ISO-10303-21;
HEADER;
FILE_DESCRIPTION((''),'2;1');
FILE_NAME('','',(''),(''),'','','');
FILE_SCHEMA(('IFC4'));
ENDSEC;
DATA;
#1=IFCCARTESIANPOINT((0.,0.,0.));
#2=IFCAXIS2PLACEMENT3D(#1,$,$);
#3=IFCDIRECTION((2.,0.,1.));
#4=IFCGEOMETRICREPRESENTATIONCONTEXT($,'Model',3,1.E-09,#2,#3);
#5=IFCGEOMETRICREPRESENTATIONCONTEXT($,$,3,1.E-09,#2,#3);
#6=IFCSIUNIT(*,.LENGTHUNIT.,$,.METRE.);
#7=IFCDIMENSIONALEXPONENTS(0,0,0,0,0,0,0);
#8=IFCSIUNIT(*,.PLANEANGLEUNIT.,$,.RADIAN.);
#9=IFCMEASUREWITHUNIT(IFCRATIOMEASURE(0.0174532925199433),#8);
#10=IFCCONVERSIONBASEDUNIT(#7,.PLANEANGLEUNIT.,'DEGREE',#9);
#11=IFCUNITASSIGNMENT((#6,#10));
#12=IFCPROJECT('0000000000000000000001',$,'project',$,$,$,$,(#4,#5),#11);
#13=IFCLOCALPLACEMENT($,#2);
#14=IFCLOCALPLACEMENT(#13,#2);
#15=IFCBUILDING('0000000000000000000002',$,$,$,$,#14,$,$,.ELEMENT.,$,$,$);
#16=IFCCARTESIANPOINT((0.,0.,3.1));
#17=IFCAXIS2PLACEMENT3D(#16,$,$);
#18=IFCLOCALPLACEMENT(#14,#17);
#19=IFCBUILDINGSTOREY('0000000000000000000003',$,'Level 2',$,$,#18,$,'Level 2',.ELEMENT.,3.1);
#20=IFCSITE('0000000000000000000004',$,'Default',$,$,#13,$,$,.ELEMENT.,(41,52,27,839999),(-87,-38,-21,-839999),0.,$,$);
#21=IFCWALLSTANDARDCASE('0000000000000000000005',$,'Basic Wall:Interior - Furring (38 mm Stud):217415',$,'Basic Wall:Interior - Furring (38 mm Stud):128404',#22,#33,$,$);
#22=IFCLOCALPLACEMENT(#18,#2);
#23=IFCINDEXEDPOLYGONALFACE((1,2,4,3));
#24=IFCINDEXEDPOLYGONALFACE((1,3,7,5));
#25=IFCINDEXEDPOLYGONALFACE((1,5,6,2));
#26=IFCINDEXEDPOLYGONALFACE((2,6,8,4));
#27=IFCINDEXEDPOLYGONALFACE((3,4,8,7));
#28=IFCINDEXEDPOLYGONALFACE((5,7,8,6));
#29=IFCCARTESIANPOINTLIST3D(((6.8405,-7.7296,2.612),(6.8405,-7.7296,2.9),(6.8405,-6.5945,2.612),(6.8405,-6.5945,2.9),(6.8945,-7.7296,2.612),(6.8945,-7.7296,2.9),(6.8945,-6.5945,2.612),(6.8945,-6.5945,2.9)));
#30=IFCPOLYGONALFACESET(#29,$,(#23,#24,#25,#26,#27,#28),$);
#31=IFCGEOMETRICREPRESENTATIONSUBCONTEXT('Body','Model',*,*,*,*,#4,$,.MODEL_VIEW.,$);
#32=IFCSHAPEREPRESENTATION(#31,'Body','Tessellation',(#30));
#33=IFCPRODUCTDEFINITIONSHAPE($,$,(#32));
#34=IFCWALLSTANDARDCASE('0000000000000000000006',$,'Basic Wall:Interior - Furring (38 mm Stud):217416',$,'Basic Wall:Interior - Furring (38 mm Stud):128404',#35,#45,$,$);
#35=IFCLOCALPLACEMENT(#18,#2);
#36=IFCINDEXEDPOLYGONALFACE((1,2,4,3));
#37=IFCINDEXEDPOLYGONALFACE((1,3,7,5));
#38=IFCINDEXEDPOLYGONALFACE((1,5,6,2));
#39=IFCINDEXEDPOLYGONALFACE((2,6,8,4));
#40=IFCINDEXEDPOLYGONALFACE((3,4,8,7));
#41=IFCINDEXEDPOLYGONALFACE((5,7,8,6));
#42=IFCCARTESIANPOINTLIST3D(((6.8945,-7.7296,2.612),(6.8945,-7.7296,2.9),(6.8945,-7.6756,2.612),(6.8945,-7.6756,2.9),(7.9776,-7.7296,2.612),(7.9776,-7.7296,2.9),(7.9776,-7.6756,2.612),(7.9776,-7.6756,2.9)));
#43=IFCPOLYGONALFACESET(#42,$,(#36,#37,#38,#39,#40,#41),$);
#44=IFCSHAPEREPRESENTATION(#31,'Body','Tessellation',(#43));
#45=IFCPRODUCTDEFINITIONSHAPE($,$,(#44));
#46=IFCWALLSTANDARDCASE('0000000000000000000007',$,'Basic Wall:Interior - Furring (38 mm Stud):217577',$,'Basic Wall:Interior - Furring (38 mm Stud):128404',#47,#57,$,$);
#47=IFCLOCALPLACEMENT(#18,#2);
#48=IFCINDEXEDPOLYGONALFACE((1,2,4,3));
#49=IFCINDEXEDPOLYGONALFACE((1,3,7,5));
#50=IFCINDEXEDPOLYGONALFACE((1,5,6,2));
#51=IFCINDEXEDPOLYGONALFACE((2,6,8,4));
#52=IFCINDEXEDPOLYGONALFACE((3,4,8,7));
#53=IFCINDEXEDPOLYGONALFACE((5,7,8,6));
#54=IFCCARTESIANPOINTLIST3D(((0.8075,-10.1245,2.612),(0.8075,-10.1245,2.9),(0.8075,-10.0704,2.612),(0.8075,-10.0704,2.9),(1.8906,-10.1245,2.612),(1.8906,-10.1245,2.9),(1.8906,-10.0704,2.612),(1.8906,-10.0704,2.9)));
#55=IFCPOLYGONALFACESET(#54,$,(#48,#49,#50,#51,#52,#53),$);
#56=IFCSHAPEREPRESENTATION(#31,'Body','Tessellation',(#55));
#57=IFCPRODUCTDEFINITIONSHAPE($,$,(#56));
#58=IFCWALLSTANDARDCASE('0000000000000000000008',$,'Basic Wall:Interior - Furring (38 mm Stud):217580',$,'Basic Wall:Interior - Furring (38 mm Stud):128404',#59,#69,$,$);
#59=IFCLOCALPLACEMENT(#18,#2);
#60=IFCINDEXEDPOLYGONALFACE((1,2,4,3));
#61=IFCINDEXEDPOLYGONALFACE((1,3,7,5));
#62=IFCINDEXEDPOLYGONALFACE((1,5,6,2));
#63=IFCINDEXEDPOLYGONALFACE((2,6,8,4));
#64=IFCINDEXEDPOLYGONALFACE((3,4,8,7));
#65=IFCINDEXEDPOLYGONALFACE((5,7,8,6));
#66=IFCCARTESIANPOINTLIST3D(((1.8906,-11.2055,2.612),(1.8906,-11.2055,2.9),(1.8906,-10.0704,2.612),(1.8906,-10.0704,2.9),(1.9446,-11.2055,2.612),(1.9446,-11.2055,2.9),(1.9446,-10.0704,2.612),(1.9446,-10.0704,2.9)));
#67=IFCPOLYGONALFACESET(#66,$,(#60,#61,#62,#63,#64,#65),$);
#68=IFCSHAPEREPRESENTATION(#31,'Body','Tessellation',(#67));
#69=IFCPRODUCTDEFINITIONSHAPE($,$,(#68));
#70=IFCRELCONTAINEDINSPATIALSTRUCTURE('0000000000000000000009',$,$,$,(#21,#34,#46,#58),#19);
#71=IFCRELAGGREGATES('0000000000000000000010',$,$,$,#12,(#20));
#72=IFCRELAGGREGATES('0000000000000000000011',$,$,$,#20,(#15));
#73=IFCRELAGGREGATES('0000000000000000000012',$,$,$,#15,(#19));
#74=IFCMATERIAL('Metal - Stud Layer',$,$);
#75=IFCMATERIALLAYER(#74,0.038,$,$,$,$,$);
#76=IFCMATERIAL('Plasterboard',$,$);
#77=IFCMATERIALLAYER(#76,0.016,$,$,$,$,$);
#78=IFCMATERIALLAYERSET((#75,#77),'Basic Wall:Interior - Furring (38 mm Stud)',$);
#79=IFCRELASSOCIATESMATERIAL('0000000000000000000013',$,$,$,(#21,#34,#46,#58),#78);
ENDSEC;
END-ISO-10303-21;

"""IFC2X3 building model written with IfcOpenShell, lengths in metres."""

from ifc_helpers import new_model, entity, si_unit, converted_unit, direction, frame, frame_2d, origin, place, context, subcontext, project, spatial, rectangle, extrude, material, layer, layer_set, layer_usage, element, save


model = new_model("IFC2X3")

# Units and contexts
model_context = context("Model", 3, precision=1e-09, world=origin(), true_north=direction((2.0, 0.0, 1.0)))
context_of_model = context(None, 3, precision=1e-09, world=origin(), true_north=direction((2.0, 0.0, 1.0)))
body_context = subcontext(model_context, "Body", "Model", "MODEL_VIEW")
ifc_project = project(units=[si_unit("LENGTHUNIT", "METRE"), converted_unit("PLANEANGLEUNIT", "DEGREE", entity("IfcRatioMeasure", 0.0174532925199433), si_unit("PLANEANGLEUNIT", "RADIAN"), dimensions=[0, 0, 0, 0, 0, 0, 0])], contexts=[model_context, context_of_model])

# Site, building, storey
site_placement = place(None, origin())
site = spatial("IfcSite", under=ifc_project, at=site_placement, Name="Default", CompositionType="ELEMENT", RefLatitude=(41, 52, 27, 839999), RefLongitude=(-87, -38, -21, -839999), RefElevation=0.0)
building_placement = place(site_placement, origin())
building = spatial("IfcBuilding", under=site, at=building_placement, CompositionType="ELEMENT")
storey_placement = place(building_placement, frame((0.0, 0.0, 3.1)))
storey = spatial("IfcBuildingStorey", under=building, at=storey_placement, Name="Level 2", LongName="Level 2", CompositionType="ELEMENT", Elevation=3.1)

# Shared definitions
ifc_material_1 = material(Name="Plasterboard")
ifc_material_2 = material(Name="Metal - Stud Layer")

# Walls
ifc_layer_1 = layer(ifc_material_2, 0.038)
ifc_layer_2 = layer(ifc_material_1, 0.016)
ifc_layer_set_1 = layer_set([ifc_layer_1, ifc_layer_2], Name="Basic Wall:Interior - Furring (38 mm Stud)")
ifc_layer_usage_1 = layer_usage(ifc_layer_set_1, "AXIS2", "NEGATIVE", 0.027)
wall_1_placement = place(storey_placement, frame((6.8675, -7.7296, 2.612), z_axis=(0.0, 0.0, 1.0), x_axis=(0.0, 1.0, 0.0)))
element("IfcWallStandardCase", 1, at=wall_1_placement, inside=storey, material=ifc_layer_usage_1, Name="Basic Wall:Interior - Furring (38 mm Stud):217415", ObjectType="Basic Wall:Interior - Furring (38 mm Stud):128404", context=body_context, shape_type="SweptSolid", body=[
    extrude(rectangle(XDim=1.1351, YDim=0.054, at=frame_2d((0.5675, 0.0), x_axis=(-1.0, 0.0))), origin(), (0.0, 0.0, 1.0), 0.288),
])
ifc_layer_usage_2 = layer_usage(ifc_layer_set_1, "AXIS2", "NEGATIVE", 0.027)
wall_2_placement = place(storey_placement, frame((7.9776, -7.7026, 2.612), z_axis=(0.0, 0.0, 1.0), x_axis=(-1.0, 0.0, 0.0)))
element("IfcWallStandardCase", 2, at=wall_2_placement, inside=storey, material=ifc_layer_usage_2, Name="Basic Wall:Interior - Furring (38 mm Stud):217416", ObjectType="Basic Wall:Interior - Furring (38 mm Stud):128404", context=body_context, shape_type="SweptSolid", body=[
    extrude(rectangle(XDim=1.0831, YDim=0.054, at=frame_2d((0.5415, 0.0), x_axis=(-1.0, 0.0))), origin(), (0.0, 0.0, 1.0), 0.288),
])
ifc_layer_usage_3 = layer_usage(ifc_layer_set_1, "AXIS2", "NEGATIVE", 0.027)
wall_3_placement = place(storey_placement, frame((0.8075, -10.0975, 2.612)))
element("IfcWallStandardCase", 3, at=wall_3_placement, inside=storey, material=ifc_layer_usage_3, Name="Basic Wall:Interior - Furring (38 mm Stud):217577", ObjectType="Basic Wall:Interior - Furring (38 mm Stud):128404", context=body_context, shape_type="SweptSolid", body=[
    extrude(rectangle(XDim=1.0831, YDim=0.054, at=frame_2d((0.5415, 0.0), x_axis=(-1.0, 0.0))), origin(), (0.0, 0.0, 1.0), 0.288),
])
ifc_layer_usage_4 = layer_usage(ifc_layer_set_1, "AXIS2", "NEGATIVE", 0.027)
wall_4_placement = place(storey_placement, frame((1.9176, -10.0704, 2.612), z_axis=(0.0, 0.0, 1.0), x_axis=(0.0, -1.0, 0.0)))
element("IfcWallStandardCase", 4, at=wall_4_placement, inside=storey, material=ifc_layer_usage_4, Name="Basic Wall:Interior - Furring (38 mm Stud):217580", ObjectType="Basic Wall:Interior - Furring (38 mm Stud):128404", context=body_context, shape_type="SweptSolid", body=[
    extrude(rectangle(XDim=1.1351, YDim=0.054, at=frame_2d((0.5675, 0.0), x_axis=(-1.0, 0.0))), origin(), (0.0, 0.0, 1.0), 0.288),
])

save(model, "model.ifc")
